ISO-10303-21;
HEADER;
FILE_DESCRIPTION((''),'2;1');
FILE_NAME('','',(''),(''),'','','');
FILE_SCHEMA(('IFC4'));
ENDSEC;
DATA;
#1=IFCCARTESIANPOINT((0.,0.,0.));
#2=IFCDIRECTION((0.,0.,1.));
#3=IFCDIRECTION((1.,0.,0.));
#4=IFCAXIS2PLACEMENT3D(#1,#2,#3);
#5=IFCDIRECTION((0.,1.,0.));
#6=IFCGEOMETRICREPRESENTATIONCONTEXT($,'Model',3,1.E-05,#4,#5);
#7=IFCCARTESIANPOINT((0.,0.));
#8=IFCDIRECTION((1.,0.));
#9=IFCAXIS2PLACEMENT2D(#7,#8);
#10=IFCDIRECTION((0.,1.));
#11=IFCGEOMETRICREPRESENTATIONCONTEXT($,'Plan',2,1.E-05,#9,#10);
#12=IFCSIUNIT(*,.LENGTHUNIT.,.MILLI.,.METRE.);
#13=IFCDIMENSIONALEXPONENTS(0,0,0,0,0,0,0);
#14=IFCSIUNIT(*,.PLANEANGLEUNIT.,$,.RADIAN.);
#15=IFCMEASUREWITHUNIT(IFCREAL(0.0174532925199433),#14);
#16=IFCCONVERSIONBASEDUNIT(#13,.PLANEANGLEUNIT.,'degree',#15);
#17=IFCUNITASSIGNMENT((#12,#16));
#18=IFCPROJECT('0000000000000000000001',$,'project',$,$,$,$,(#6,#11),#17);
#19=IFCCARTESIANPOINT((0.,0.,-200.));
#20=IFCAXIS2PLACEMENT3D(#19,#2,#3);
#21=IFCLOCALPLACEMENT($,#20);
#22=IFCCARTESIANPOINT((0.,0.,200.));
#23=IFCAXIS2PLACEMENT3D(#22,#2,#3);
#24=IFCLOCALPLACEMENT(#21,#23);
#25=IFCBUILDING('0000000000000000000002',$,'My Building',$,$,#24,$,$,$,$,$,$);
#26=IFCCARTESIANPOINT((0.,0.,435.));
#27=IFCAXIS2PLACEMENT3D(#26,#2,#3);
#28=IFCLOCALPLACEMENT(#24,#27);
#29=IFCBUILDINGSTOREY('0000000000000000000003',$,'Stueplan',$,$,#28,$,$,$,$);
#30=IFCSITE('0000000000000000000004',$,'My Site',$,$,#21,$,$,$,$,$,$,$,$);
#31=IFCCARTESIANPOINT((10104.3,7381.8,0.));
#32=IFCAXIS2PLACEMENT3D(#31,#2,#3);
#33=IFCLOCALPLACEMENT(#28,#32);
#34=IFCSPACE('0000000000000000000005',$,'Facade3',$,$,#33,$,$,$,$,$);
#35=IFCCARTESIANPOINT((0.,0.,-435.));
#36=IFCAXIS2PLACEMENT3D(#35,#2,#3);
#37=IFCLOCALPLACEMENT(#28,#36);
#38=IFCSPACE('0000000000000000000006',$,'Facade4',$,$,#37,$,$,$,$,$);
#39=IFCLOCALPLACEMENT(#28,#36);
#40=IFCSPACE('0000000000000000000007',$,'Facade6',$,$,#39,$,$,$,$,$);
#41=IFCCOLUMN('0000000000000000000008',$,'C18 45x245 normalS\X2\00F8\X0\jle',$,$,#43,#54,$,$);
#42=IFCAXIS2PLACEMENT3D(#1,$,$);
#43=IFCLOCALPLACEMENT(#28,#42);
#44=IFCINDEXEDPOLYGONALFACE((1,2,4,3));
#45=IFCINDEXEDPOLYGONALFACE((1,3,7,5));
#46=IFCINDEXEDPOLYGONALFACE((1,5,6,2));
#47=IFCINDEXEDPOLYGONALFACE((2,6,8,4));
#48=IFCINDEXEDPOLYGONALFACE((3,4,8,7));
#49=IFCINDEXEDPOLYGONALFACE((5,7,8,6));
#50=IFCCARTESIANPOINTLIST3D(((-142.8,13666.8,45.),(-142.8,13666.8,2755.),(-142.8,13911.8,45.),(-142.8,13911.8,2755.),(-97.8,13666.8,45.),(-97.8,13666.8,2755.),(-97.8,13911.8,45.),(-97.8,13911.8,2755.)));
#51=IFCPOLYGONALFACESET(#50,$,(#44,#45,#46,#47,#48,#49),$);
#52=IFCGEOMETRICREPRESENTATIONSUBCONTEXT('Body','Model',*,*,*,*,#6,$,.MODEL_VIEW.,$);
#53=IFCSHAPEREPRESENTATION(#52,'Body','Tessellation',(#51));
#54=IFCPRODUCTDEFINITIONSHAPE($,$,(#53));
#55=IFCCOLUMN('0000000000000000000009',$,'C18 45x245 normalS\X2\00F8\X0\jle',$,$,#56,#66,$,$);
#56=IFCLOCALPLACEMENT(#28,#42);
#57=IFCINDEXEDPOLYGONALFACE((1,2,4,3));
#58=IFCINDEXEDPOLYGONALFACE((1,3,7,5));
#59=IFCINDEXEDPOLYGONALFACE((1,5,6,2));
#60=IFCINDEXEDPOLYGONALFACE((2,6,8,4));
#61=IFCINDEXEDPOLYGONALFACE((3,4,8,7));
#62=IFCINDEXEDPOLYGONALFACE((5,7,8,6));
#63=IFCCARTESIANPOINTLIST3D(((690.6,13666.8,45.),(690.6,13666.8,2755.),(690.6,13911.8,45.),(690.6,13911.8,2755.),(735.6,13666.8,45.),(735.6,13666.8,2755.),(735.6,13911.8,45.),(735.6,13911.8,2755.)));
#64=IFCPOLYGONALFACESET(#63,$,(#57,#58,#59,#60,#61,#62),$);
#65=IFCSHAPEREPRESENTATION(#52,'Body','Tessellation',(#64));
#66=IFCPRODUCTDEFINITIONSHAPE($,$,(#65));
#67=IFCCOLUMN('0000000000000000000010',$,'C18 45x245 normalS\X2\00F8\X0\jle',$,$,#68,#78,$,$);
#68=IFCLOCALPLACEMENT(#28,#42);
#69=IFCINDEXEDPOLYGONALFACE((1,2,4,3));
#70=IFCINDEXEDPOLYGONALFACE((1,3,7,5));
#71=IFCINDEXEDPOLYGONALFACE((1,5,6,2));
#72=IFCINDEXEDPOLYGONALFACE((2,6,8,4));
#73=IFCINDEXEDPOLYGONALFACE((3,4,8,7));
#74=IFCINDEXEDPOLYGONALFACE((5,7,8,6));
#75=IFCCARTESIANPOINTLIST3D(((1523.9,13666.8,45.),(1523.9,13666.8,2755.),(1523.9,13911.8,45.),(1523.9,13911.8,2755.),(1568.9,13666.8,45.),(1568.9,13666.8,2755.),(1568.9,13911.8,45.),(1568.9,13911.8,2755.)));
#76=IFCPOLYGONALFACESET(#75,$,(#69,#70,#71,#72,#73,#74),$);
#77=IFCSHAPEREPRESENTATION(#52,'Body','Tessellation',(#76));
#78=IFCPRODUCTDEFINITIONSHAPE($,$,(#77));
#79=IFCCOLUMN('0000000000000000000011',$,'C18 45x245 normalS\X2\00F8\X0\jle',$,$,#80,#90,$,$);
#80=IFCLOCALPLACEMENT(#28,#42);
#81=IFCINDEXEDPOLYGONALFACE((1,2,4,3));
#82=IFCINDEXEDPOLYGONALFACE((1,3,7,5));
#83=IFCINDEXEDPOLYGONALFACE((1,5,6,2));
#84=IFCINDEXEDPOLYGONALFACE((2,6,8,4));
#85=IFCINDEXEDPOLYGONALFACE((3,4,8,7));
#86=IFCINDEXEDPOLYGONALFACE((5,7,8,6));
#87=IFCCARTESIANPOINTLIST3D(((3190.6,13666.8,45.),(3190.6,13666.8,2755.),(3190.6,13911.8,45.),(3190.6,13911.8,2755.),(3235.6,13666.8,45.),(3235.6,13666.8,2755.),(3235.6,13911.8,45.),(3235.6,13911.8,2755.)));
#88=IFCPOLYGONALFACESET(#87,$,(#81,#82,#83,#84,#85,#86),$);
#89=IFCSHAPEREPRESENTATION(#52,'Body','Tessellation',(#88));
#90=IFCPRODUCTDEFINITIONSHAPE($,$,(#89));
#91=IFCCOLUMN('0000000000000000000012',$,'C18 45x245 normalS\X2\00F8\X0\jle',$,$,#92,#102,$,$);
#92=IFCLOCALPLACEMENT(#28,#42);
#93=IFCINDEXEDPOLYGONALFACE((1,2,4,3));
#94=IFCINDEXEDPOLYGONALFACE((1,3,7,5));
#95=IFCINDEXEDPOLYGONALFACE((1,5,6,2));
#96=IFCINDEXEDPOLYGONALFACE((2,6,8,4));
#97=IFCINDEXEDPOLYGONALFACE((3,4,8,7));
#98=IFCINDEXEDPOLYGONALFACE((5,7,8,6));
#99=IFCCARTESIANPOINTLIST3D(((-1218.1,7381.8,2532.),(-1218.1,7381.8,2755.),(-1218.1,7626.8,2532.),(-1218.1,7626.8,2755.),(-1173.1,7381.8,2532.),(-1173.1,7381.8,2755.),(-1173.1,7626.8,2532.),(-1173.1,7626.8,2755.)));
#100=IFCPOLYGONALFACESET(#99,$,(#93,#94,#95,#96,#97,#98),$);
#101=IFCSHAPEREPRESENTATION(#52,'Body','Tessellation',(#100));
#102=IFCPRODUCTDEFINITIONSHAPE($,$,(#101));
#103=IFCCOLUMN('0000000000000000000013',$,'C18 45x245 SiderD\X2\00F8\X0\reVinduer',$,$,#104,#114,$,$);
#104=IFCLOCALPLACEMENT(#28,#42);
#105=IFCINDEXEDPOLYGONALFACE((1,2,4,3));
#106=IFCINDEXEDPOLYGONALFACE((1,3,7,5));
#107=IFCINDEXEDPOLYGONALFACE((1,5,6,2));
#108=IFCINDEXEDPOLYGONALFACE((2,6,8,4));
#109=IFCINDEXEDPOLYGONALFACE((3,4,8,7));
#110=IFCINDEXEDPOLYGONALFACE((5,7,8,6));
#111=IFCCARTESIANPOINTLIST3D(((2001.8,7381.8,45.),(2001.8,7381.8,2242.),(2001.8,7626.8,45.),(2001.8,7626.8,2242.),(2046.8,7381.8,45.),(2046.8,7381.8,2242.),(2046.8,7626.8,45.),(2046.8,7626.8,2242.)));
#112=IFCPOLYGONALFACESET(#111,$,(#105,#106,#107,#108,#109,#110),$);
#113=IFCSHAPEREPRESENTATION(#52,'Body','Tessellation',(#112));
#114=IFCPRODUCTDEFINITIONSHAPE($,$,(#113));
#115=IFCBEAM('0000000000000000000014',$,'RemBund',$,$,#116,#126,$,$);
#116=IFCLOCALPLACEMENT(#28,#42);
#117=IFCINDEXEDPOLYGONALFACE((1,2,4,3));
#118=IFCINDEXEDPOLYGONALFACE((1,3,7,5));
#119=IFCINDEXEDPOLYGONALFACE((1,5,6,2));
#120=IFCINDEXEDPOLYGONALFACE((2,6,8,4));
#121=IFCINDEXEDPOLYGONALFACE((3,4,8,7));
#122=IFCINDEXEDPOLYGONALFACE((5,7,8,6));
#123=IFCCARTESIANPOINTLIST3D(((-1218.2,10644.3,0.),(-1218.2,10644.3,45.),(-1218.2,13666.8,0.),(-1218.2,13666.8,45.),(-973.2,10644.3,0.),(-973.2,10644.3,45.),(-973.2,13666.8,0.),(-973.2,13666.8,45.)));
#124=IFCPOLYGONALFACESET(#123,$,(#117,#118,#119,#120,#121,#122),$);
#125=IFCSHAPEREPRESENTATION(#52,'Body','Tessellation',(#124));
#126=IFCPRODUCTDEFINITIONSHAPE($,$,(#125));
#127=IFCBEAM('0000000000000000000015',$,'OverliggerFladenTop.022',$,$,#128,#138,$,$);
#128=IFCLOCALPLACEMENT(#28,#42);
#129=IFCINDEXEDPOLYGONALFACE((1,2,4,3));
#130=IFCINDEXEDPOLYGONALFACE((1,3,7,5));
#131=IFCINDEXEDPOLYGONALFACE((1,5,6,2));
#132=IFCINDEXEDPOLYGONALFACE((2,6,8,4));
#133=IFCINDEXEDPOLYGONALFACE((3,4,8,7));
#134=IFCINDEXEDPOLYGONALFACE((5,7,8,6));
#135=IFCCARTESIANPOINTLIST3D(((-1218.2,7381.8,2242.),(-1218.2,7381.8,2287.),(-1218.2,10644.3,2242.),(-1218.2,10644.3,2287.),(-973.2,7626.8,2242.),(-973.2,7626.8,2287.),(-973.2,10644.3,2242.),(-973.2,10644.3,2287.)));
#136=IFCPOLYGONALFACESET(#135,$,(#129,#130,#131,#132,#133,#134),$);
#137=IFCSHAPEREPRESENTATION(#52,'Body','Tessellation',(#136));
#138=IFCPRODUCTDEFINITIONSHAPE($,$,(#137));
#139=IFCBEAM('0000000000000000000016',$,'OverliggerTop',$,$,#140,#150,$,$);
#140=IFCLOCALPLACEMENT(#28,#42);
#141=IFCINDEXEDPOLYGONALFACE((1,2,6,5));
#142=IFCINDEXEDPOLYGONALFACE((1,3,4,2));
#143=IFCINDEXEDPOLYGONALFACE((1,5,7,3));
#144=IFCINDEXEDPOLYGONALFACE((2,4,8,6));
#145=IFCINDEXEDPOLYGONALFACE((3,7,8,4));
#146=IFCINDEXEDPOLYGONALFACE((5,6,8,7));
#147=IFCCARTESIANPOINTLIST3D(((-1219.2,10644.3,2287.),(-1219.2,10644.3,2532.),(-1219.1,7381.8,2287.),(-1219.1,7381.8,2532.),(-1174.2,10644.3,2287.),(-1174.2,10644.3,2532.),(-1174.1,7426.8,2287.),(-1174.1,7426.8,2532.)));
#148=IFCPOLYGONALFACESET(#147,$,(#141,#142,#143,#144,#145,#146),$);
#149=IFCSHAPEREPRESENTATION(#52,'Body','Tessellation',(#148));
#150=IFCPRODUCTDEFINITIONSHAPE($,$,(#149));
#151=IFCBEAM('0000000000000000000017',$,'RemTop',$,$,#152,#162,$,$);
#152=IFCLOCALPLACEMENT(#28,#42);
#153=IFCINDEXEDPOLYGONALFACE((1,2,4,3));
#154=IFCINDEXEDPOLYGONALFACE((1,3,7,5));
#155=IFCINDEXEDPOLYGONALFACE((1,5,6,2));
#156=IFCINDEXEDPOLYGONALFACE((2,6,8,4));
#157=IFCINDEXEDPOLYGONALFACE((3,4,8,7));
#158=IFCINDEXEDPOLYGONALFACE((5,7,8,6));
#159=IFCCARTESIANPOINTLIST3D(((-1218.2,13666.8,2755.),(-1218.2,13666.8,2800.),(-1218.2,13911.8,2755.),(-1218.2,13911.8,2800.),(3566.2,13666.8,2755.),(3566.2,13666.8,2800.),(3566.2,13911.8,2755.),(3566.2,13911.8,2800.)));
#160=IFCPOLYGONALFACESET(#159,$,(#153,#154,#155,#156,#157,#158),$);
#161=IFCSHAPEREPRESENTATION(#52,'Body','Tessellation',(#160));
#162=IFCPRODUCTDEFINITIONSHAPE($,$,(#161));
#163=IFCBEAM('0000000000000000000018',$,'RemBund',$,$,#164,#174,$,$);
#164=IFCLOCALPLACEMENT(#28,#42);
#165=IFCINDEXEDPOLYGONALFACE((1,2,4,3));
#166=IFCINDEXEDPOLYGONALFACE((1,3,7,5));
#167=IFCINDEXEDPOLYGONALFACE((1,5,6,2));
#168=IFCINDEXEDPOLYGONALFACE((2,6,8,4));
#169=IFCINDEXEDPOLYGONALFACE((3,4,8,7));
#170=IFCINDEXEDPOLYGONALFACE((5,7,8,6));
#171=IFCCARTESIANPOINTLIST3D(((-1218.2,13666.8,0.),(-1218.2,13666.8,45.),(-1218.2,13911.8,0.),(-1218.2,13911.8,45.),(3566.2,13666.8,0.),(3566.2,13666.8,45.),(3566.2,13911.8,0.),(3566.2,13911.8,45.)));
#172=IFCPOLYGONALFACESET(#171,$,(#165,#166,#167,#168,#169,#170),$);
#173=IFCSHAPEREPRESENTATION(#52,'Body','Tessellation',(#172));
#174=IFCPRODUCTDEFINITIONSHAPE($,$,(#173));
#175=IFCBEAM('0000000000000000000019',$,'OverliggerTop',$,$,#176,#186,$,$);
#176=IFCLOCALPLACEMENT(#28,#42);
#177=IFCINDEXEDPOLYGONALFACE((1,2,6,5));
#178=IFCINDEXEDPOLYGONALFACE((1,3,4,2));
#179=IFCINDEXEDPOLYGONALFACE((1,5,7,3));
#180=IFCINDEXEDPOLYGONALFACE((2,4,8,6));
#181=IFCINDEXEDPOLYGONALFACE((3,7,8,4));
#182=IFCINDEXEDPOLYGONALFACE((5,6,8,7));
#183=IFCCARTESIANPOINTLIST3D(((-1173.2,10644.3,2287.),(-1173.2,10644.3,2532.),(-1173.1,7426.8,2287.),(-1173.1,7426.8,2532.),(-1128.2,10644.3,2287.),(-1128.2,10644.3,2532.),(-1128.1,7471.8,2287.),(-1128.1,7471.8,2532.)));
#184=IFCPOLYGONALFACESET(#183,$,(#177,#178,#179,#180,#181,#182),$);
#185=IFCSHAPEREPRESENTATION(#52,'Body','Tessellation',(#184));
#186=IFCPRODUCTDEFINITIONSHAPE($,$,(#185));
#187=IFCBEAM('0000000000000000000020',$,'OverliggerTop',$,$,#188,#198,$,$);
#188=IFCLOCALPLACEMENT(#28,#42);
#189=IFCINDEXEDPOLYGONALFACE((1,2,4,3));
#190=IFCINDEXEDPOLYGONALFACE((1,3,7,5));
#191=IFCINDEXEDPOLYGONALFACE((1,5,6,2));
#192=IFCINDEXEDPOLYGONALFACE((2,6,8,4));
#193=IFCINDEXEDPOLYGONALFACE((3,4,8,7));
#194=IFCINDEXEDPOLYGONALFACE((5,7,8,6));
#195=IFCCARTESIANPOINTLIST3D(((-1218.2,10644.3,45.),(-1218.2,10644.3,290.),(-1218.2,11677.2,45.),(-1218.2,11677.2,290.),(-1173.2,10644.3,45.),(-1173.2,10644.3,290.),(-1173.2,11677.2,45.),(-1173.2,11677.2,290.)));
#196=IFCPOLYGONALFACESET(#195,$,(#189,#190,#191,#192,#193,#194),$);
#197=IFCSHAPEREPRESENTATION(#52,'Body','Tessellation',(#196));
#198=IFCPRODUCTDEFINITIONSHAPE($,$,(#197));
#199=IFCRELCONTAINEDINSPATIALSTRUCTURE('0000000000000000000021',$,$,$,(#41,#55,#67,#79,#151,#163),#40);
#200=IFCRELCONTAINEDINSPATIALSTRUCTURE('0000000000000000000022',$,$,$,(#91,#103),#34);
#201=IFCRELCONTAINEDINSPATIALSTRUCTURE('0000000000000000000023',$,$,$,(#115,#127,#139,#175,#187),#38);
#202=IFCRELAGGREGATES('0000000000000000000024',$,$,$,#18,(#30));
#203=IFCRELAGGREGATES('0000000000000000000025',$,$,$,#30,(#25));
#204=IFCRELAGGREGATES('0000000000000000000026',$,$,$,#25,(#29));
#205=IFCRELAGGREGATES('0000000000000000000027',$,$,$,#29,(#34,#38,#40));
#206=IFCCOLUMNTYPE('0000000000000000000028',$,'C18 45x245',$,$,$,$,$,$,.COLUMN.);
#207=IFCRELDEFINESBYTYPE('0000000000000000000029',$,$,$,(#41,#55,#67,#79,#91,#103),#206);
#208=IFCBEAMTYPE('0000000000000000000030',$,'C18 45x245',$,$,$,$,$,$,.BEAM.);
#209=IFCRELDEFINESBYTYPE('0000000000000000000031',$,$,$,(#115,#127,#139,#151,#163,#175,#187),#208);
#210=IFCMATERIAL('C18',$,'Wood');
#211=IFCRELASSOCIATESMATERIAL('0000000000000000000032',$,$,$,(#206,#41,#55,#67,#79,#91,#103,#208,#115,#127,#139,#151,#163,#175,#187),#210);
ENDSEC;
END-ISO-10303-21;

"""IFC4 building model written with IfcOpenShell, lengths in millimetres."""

from ifc_helpers import new_model, entity, si_unit, converted_unit, direction, frame, origin_with_axes, origin_2d_with_axis, place, context, subcontext, project, spatial, rectangle, extrude, clip, halfspace, material, material_profile, profile_set, profile_usage, type_object, element, save


model = new_model("IFC4")

# Units and contexts
model_context = context("Model", 3, precision=1e-05, world=origin_with_axes(), true_north=direction((0.0, 1.0, 0.0)))
plan_context = context("Plan", 2, precision=1e-05, world=origin_2d_with_axis(), true_north=direction((0.0, 1.0)))
body_context_1 = subcontext(model_context, "Body", "Model", "MODEL_VIEW")
ifc_project = project(units=[si_unit("LENGTHUNIT", "METRE", prefix="MILLI"), converted_unit("PLANEANGLEUNIT", "degree", entity("IfcReal", 0.0174532925199433), si_unit("PLANEANGLEUNIT", "RADIAN"), dimensions=[0, 0, 0, 0, 0, 0, 0])], contexts=[model_context, plan_context])

# Site, building, storey, space
site_placement = place(None, frame((0.0, 0.0, -200.0), z_axis=(0.0, 0.0, 1.0), x_axis=(1.0, 0.0, 0.0)))
site = spatial("IfcSite", under=ifc_project, at=site_placement, Name="My Site")
building_placement = place(site_placement, frame((0.0, 0.0, 200.0), z_axis=(0.0, 0.0, 1.0), x_axis=(1.0, 0.0, 0.0)))
building = spatial("IfcBuilding", under=site, at=building_placement, Name="My Building")
storey_placement = place(building_placement, frame((0.0, 0.0, 435.0), z_axis=(0.0, 0.0, 1.0), x_axis=(1.0, 0.0, 0.0)))
storey = spatial("IfcBuildingStorey", under=building, at=storey_placement, Name="Stueplan")
space_1_placement = place(storey_placement, frame((10104.3, 7381.8, 0.0), z_axis=(0.0, 0.0, 1.0), x_axis=(1.0, 0.0, 0.0)))
space_1 = spatial("IfcSpace", under=storey, at=space_1_placement, Name="Facade3")

# Shared definitions
ifc_material_1 = material(Name="C18", Category="Wood")
ifc_material_profile_1 = material_profile(ifc_material_1, rectangle(XDim=45.0, YDim=245.0))
ifc_profile_set_1 = profile_set([ifc_material_profile_1], Name="woodStructural")
column_type = type_object("IfcColumnType", Name="C18 45x245", PredefinedType="COLUMN", material=ifc_profile_set_1)

# Shared definitions
space_2_placement = place(storey_placement, frame((0.0, 0.0, -435.0), z_axis=(0.0, 0.0, 1.0), x_axis=(1.0, 0.0, 0.0)))
space_2 = spatial("IfcSpace", under=storey, at=space_2_placement, Name="Facade4")

# Shared definitions
space_3_placement = place(storey_placement, frame((0.0, 0.0, -435.0), z_axis=(0.0, 0.0, 1.0), x_axis=(1.0, 0.0, 0.0)))
space_3 = spatial("IfcSpace", under=storey, at=space_3_placement, Name="Facade6")

# Columns
ifc_profile_usage_1 = profile_usage(ifc_profile_set_1, cardinal=9)
column_1_placement = place(space_3_placement, frame((-142.8, 13911.8, 480.0), z_axis=(0.0, 0.0, 1.0), x_axis=(1.0, 0.0, 0.0)))
element("IfcColumn", 1, at=column_1_placement, inside=space_3, type_object=column_type, material=ifc_profile_usage_1, Name="C18 45x245 normalSøjle", context=body_context_1, shape_type="SweptSolid", body=[
    extrude(rectangle(XDim=45.0, YDim=245.0), frame((22.5, -122.5, 0.0), z_axis=(0.0, 0.0, 1.0), x_axis=(1.0, 0.0, 0.0)), (0.0, 0.0, 1.0), 2710.0),
])
ifc_profile_usage_2 = profile_usage(ifc_profile_set_1, cardinal=9)
column_2_placement = place(space_3_placement, frame((690.6, 13911.8, 480.0), z_axis=(0.0, 0.0, 1.0), x_axis=(1.0, 0.0, 0.0)))
element("IfcColumn", 2, at=column_2_placement, inside=space_3, type_object=column_type, material=ifc_profile_usage_2, Name="C18 45x245 normalSøjle", context=body_context_1, shape_type="SweptSolid", body=[
    extrude(rectangle(XDim=45.0, YDim=245.0), frame((22.5, -122.5, 0.0), z_axis=(0.0, 0.0, 1.0), x_axis=(1.0, 0.0, 0.0)), (0.0, 0.0, 1.0), 2710.0),
])
ifc_profile_usage_3 = profile_usage(ifc_profile_set_1, cardinal=9)
column_3_placement = place(space_3_placement, frame((1523.9, 13911.8, 480.0), z_axis=(0.0, 0.0, 1.0), x_axis=(1.0, 0.0, 0.0)))
element("IfcColumn", 3, at=column_3_placement, inside=space_3, type_object=column_type, material=ifc_profile_usage_3, Name="C18 45x245 normalSøjle", context=body_context_1, shape_type="SweptSolid", body=[
    extrude(rectangle(XDim=45.0, YDim=245.0), frame((22.5, -122.5, 0.0), z_axis=(0.0, 0.0, 1.0), x_axis=(1.0, 0.0, 0.0)), (0.0, 0.0, 1.0), 2710.0),
])
ifc_profile_usage_4 = profile_usage(ifc_profile_set_1, cardinal=9)
column_4_placement = place(space_3_placement, frame((3190.6, 13911.8, 480.0), z_axis=(0.0, 0.0, 1.0), x_axis=(1.0, 0.0, 0.0)))
element("IfcColumn", 4, at=column_4_placement, inside=space_3, type_object=column_type, material=ifc_profile_usage_4, Name="C18 45x245 normalSøjle", context=body_context_1, shape_type="SweptSolid", body=[
    extrude(rectangle(XDim=45.0, YDim=245.0), frame((22.5, -122.5, 0.0), z_axis=(0.0, 0.0, 1.0), x_axis=(1.0, 0.0, 0.0)), (0.0, 0.0, 1.0), 2710.0),
])
ifc_profile_usage_5 = profile_usage(ifc_profile_set_1, cardinal=9)
column_5_placement = place(space_1_placement, frame((-11322.5, 245.0, 2532.0), z_axis=(0.0, 0.0, 1.0), x_axis=(1.0, 0.0, 0.0)))
element("IfcColumn", 5, at=column_5_placement, inside=space_1, type_object=column_type, material=ifc_profile_usage_5, Name="C18 45x245 normalSøjle", context=body_context_1, shape_type="SweptSolid", body=[
    extrude(rectangle(XDim=45.0, YDim=245.0), frame((22.5, -122.5, 0.0), z_axis=(0.0, 0.0, 1.0), x_axis=(1.0, 0.0, 0.0)), (0.0, 0.0, 1.0), 223.0),
])
ifc_profile_usage_6 = profile_usage(ifc_profile_set_1, cardinal=9)
column_6_placement = place(space_1_placement, frame((-8102.5, 245.0, 45.0), z_axis=(0.0, 0.0, 1.0), x_axis=(1.0, 0.0, 0.0)))
element("IfcColumn", 6, at=column_6_placement, inside=space_1, type_object=column_type, material=ifc_profile_usage_6, Name="C18 45x245 SiderDøreVinduer", context=body_context_1, shape_type="SweptSolid", body=[
    extrude(rectangle(XDim=45.0, YDim=245.0), frame((22.5, -122.5, 0.0), z_axis=(0.0, 0.0, 1.0), x_axis=(1.0, 0.0, 0.0)), (0.0, 0.0, 1.0), 2197.0),
])

# Beams
ifc_material_profile_2 = material_profile(ifc_material_1, rectangle(XDim=45.0, YDim=245.0), Name="concrete")
ifc_profile_set_2 = profile_set([ifc_material_profile_2], Name="woodStructural")
ifc_profile_usage_7 = profile_usage(ifc_profile_set_2)
beam_type = type_object("IfcBeamType", Name="C18 45x245", PredefinedType="BEAM", material=ifc_profile_set_2)
beam_1_placement = place(space_2_placement, frame((-1095.7, 13666.8, 457.5), z_axis=(0.0, -1.0, 0.0), x_axis=(0.0, 0.0, 1.0)))
element("IfcBeam", 7, at=beam_1_placement, inside=space_2, type_object=beam_type, material=ifc_profile_usage_7, Name="RemBund", context=body_context_1, shape_type="SweptSolid", body=[
    extrude(rectangle(XDim=45.0, YDim=245.0), origin_with_axes(), (0.0, 0.0, 1.0), 3022.5),
])
ifc_profile_usage_8 = profile_usage(ifc_profile_set_2)
beam_2_placement = place(space_2_placement, frame((-1095.7, 10644.3, 2699.5), z_axis=(0.0, -1.0, 0.0), x_axis=(0.0, 0.0, 1.0)))
element("IfcBeam", 8, at=beam_2_placement, inside=space_2, type_object=beam_type, material=ifc_profile_usage_8, Name="OverliggerFladenTop.022", context=body_context_1, shape_type="Clipping", body=[
    clip(extrude(rectangle(XDim=45.0, YDim=245.0), origin_with_axes(), (0.0, 0.0, 1.0), 3262.5), halfspace(frame((-2699.5, 122.5, 3262.5), z_axis=(0.0, -0.707107, 0.707107), x_axis=(-1.0, 0.0, 0.0)), False)),
])
ifc_profile_usage_9 = profile_usage(ifc_profile_set_2)
beam_3_placement = place(space_2_placement, frame((-1196.7, 10644.3, 2844.5), z_axis=(0.0, -1.0, 0.0), x_axis=(-1.0, 0.0, 0.0)))
element("IfcBeam", 9, at=beam_3_placement, inside=space_2, type_object=beam_type, material=ifc_profile_usage_9, Name="OverliggerTop", context=body_context_1, shape_type="Clipping", body=[
    clip(extrude(rectangle(XDim=45.0, YDim=245.0), origin_with_axes(), (0.0, 0.0, 1.0), 3262.5), halfspace(frame((22.5, 2844.5, 3262.5), z_axis=(-0.707107, 0.0, 0.707107), x_axis=(0.0, 1.0, 0.0)), False)),
])
ifc_profile_usage_10 = profile_usage(ifc_profile_set_2)
beam_4_placement = place(space_3_placement, frame((3566.2, 13789.3, 3212.5), z_axis=(-1.0, 0.0, 0.0), x_axis=(0.0, 0.0, 1.0)))
element("IfcBeam", 10, at=beam_4_placement, inside=space_3, type_object=beam_type, material=ifc_profile_usage_10, Name="RemTop", context=body_context_1, shape_type="SweptSolid", body=[
    extrude(rectangle(XDim=45.0, YDim=245.0), origin_with_axes(), (0.0, 0.0, 1.0), 4784.4),
])
ifc_profile_usage_11 = profile_usage(ifc_profile_set_2)
beam_5_placement = place(space_3_placement, frame((3566.2, 13789.3, 457.5), z_axis=(-1.0, 0.0, 0.0), x_axis=(0.0, 0.0, 1.0)))
element("IfcBeam", 11, at=beam_5_placement, inside=space_3, type_object=beam_type, material=ifc_profile_usage_11, Name="RemBund", context=body_context_1, shape_type="SweptSolid", body=[
    extrude(rectangle(XDim=45.0, YDim=245.0), origin_with_axes(), (0.0, 0.0, 1.0), 4784.4),
])
ifc_profile_usage_12 = profile_usage(ifc_profile_set_2)
beam_6_placement = place(space_2_placement, frame((-1150.7, 10644.3, 2844.5), z_axis=(0.0, -1.0, 0.0), x_axis=(-1.0, 0.0, 0.0)))
element("IfcBeam", 12, at=beam_6_placement, inside=space_2, type_object=beam_type, material=ifc_profile_usage_12, Name="OverliggerTop", context=body_context_1, shape_type="Clipping", body=[
    clip(extrude(rectangle(XDim=45.0, YDim=245.0), origin_with_axes(), (0.0, 0.0, 1.0), 3217.5), halfspace(frame((22.5, 2844.5, 3217.5), z_axis=(-0.70711, 0.0, 0.707103), x_axis=(0.0, 1.0, 0.0)), False)),
])
ifc_profile_usage_13 = profile_usage(ifc_profile_set_2)
beam_7_placement = place(space_2_placement, frame((-1195.7, 11677.2, 602.5), z_axis=(0.0, -1.0, 0.0), x_axis=(-1.0, 0.0, 0.0)))
element("IfcBeam", 13, at=beam_7_placement, inside=space_2, type_object=beam_type, material=ifc_profile_usage_13, Name="OverliggerTop", context=body_context_1, shape_type="SweptSolid", body=[
    extrude(rectangle(XDim=45.0, YDim=245.0), origin_with_axes(), (0.0, 0.0, 1.0), 1032.9),
])

save(model, "model.ifc")
